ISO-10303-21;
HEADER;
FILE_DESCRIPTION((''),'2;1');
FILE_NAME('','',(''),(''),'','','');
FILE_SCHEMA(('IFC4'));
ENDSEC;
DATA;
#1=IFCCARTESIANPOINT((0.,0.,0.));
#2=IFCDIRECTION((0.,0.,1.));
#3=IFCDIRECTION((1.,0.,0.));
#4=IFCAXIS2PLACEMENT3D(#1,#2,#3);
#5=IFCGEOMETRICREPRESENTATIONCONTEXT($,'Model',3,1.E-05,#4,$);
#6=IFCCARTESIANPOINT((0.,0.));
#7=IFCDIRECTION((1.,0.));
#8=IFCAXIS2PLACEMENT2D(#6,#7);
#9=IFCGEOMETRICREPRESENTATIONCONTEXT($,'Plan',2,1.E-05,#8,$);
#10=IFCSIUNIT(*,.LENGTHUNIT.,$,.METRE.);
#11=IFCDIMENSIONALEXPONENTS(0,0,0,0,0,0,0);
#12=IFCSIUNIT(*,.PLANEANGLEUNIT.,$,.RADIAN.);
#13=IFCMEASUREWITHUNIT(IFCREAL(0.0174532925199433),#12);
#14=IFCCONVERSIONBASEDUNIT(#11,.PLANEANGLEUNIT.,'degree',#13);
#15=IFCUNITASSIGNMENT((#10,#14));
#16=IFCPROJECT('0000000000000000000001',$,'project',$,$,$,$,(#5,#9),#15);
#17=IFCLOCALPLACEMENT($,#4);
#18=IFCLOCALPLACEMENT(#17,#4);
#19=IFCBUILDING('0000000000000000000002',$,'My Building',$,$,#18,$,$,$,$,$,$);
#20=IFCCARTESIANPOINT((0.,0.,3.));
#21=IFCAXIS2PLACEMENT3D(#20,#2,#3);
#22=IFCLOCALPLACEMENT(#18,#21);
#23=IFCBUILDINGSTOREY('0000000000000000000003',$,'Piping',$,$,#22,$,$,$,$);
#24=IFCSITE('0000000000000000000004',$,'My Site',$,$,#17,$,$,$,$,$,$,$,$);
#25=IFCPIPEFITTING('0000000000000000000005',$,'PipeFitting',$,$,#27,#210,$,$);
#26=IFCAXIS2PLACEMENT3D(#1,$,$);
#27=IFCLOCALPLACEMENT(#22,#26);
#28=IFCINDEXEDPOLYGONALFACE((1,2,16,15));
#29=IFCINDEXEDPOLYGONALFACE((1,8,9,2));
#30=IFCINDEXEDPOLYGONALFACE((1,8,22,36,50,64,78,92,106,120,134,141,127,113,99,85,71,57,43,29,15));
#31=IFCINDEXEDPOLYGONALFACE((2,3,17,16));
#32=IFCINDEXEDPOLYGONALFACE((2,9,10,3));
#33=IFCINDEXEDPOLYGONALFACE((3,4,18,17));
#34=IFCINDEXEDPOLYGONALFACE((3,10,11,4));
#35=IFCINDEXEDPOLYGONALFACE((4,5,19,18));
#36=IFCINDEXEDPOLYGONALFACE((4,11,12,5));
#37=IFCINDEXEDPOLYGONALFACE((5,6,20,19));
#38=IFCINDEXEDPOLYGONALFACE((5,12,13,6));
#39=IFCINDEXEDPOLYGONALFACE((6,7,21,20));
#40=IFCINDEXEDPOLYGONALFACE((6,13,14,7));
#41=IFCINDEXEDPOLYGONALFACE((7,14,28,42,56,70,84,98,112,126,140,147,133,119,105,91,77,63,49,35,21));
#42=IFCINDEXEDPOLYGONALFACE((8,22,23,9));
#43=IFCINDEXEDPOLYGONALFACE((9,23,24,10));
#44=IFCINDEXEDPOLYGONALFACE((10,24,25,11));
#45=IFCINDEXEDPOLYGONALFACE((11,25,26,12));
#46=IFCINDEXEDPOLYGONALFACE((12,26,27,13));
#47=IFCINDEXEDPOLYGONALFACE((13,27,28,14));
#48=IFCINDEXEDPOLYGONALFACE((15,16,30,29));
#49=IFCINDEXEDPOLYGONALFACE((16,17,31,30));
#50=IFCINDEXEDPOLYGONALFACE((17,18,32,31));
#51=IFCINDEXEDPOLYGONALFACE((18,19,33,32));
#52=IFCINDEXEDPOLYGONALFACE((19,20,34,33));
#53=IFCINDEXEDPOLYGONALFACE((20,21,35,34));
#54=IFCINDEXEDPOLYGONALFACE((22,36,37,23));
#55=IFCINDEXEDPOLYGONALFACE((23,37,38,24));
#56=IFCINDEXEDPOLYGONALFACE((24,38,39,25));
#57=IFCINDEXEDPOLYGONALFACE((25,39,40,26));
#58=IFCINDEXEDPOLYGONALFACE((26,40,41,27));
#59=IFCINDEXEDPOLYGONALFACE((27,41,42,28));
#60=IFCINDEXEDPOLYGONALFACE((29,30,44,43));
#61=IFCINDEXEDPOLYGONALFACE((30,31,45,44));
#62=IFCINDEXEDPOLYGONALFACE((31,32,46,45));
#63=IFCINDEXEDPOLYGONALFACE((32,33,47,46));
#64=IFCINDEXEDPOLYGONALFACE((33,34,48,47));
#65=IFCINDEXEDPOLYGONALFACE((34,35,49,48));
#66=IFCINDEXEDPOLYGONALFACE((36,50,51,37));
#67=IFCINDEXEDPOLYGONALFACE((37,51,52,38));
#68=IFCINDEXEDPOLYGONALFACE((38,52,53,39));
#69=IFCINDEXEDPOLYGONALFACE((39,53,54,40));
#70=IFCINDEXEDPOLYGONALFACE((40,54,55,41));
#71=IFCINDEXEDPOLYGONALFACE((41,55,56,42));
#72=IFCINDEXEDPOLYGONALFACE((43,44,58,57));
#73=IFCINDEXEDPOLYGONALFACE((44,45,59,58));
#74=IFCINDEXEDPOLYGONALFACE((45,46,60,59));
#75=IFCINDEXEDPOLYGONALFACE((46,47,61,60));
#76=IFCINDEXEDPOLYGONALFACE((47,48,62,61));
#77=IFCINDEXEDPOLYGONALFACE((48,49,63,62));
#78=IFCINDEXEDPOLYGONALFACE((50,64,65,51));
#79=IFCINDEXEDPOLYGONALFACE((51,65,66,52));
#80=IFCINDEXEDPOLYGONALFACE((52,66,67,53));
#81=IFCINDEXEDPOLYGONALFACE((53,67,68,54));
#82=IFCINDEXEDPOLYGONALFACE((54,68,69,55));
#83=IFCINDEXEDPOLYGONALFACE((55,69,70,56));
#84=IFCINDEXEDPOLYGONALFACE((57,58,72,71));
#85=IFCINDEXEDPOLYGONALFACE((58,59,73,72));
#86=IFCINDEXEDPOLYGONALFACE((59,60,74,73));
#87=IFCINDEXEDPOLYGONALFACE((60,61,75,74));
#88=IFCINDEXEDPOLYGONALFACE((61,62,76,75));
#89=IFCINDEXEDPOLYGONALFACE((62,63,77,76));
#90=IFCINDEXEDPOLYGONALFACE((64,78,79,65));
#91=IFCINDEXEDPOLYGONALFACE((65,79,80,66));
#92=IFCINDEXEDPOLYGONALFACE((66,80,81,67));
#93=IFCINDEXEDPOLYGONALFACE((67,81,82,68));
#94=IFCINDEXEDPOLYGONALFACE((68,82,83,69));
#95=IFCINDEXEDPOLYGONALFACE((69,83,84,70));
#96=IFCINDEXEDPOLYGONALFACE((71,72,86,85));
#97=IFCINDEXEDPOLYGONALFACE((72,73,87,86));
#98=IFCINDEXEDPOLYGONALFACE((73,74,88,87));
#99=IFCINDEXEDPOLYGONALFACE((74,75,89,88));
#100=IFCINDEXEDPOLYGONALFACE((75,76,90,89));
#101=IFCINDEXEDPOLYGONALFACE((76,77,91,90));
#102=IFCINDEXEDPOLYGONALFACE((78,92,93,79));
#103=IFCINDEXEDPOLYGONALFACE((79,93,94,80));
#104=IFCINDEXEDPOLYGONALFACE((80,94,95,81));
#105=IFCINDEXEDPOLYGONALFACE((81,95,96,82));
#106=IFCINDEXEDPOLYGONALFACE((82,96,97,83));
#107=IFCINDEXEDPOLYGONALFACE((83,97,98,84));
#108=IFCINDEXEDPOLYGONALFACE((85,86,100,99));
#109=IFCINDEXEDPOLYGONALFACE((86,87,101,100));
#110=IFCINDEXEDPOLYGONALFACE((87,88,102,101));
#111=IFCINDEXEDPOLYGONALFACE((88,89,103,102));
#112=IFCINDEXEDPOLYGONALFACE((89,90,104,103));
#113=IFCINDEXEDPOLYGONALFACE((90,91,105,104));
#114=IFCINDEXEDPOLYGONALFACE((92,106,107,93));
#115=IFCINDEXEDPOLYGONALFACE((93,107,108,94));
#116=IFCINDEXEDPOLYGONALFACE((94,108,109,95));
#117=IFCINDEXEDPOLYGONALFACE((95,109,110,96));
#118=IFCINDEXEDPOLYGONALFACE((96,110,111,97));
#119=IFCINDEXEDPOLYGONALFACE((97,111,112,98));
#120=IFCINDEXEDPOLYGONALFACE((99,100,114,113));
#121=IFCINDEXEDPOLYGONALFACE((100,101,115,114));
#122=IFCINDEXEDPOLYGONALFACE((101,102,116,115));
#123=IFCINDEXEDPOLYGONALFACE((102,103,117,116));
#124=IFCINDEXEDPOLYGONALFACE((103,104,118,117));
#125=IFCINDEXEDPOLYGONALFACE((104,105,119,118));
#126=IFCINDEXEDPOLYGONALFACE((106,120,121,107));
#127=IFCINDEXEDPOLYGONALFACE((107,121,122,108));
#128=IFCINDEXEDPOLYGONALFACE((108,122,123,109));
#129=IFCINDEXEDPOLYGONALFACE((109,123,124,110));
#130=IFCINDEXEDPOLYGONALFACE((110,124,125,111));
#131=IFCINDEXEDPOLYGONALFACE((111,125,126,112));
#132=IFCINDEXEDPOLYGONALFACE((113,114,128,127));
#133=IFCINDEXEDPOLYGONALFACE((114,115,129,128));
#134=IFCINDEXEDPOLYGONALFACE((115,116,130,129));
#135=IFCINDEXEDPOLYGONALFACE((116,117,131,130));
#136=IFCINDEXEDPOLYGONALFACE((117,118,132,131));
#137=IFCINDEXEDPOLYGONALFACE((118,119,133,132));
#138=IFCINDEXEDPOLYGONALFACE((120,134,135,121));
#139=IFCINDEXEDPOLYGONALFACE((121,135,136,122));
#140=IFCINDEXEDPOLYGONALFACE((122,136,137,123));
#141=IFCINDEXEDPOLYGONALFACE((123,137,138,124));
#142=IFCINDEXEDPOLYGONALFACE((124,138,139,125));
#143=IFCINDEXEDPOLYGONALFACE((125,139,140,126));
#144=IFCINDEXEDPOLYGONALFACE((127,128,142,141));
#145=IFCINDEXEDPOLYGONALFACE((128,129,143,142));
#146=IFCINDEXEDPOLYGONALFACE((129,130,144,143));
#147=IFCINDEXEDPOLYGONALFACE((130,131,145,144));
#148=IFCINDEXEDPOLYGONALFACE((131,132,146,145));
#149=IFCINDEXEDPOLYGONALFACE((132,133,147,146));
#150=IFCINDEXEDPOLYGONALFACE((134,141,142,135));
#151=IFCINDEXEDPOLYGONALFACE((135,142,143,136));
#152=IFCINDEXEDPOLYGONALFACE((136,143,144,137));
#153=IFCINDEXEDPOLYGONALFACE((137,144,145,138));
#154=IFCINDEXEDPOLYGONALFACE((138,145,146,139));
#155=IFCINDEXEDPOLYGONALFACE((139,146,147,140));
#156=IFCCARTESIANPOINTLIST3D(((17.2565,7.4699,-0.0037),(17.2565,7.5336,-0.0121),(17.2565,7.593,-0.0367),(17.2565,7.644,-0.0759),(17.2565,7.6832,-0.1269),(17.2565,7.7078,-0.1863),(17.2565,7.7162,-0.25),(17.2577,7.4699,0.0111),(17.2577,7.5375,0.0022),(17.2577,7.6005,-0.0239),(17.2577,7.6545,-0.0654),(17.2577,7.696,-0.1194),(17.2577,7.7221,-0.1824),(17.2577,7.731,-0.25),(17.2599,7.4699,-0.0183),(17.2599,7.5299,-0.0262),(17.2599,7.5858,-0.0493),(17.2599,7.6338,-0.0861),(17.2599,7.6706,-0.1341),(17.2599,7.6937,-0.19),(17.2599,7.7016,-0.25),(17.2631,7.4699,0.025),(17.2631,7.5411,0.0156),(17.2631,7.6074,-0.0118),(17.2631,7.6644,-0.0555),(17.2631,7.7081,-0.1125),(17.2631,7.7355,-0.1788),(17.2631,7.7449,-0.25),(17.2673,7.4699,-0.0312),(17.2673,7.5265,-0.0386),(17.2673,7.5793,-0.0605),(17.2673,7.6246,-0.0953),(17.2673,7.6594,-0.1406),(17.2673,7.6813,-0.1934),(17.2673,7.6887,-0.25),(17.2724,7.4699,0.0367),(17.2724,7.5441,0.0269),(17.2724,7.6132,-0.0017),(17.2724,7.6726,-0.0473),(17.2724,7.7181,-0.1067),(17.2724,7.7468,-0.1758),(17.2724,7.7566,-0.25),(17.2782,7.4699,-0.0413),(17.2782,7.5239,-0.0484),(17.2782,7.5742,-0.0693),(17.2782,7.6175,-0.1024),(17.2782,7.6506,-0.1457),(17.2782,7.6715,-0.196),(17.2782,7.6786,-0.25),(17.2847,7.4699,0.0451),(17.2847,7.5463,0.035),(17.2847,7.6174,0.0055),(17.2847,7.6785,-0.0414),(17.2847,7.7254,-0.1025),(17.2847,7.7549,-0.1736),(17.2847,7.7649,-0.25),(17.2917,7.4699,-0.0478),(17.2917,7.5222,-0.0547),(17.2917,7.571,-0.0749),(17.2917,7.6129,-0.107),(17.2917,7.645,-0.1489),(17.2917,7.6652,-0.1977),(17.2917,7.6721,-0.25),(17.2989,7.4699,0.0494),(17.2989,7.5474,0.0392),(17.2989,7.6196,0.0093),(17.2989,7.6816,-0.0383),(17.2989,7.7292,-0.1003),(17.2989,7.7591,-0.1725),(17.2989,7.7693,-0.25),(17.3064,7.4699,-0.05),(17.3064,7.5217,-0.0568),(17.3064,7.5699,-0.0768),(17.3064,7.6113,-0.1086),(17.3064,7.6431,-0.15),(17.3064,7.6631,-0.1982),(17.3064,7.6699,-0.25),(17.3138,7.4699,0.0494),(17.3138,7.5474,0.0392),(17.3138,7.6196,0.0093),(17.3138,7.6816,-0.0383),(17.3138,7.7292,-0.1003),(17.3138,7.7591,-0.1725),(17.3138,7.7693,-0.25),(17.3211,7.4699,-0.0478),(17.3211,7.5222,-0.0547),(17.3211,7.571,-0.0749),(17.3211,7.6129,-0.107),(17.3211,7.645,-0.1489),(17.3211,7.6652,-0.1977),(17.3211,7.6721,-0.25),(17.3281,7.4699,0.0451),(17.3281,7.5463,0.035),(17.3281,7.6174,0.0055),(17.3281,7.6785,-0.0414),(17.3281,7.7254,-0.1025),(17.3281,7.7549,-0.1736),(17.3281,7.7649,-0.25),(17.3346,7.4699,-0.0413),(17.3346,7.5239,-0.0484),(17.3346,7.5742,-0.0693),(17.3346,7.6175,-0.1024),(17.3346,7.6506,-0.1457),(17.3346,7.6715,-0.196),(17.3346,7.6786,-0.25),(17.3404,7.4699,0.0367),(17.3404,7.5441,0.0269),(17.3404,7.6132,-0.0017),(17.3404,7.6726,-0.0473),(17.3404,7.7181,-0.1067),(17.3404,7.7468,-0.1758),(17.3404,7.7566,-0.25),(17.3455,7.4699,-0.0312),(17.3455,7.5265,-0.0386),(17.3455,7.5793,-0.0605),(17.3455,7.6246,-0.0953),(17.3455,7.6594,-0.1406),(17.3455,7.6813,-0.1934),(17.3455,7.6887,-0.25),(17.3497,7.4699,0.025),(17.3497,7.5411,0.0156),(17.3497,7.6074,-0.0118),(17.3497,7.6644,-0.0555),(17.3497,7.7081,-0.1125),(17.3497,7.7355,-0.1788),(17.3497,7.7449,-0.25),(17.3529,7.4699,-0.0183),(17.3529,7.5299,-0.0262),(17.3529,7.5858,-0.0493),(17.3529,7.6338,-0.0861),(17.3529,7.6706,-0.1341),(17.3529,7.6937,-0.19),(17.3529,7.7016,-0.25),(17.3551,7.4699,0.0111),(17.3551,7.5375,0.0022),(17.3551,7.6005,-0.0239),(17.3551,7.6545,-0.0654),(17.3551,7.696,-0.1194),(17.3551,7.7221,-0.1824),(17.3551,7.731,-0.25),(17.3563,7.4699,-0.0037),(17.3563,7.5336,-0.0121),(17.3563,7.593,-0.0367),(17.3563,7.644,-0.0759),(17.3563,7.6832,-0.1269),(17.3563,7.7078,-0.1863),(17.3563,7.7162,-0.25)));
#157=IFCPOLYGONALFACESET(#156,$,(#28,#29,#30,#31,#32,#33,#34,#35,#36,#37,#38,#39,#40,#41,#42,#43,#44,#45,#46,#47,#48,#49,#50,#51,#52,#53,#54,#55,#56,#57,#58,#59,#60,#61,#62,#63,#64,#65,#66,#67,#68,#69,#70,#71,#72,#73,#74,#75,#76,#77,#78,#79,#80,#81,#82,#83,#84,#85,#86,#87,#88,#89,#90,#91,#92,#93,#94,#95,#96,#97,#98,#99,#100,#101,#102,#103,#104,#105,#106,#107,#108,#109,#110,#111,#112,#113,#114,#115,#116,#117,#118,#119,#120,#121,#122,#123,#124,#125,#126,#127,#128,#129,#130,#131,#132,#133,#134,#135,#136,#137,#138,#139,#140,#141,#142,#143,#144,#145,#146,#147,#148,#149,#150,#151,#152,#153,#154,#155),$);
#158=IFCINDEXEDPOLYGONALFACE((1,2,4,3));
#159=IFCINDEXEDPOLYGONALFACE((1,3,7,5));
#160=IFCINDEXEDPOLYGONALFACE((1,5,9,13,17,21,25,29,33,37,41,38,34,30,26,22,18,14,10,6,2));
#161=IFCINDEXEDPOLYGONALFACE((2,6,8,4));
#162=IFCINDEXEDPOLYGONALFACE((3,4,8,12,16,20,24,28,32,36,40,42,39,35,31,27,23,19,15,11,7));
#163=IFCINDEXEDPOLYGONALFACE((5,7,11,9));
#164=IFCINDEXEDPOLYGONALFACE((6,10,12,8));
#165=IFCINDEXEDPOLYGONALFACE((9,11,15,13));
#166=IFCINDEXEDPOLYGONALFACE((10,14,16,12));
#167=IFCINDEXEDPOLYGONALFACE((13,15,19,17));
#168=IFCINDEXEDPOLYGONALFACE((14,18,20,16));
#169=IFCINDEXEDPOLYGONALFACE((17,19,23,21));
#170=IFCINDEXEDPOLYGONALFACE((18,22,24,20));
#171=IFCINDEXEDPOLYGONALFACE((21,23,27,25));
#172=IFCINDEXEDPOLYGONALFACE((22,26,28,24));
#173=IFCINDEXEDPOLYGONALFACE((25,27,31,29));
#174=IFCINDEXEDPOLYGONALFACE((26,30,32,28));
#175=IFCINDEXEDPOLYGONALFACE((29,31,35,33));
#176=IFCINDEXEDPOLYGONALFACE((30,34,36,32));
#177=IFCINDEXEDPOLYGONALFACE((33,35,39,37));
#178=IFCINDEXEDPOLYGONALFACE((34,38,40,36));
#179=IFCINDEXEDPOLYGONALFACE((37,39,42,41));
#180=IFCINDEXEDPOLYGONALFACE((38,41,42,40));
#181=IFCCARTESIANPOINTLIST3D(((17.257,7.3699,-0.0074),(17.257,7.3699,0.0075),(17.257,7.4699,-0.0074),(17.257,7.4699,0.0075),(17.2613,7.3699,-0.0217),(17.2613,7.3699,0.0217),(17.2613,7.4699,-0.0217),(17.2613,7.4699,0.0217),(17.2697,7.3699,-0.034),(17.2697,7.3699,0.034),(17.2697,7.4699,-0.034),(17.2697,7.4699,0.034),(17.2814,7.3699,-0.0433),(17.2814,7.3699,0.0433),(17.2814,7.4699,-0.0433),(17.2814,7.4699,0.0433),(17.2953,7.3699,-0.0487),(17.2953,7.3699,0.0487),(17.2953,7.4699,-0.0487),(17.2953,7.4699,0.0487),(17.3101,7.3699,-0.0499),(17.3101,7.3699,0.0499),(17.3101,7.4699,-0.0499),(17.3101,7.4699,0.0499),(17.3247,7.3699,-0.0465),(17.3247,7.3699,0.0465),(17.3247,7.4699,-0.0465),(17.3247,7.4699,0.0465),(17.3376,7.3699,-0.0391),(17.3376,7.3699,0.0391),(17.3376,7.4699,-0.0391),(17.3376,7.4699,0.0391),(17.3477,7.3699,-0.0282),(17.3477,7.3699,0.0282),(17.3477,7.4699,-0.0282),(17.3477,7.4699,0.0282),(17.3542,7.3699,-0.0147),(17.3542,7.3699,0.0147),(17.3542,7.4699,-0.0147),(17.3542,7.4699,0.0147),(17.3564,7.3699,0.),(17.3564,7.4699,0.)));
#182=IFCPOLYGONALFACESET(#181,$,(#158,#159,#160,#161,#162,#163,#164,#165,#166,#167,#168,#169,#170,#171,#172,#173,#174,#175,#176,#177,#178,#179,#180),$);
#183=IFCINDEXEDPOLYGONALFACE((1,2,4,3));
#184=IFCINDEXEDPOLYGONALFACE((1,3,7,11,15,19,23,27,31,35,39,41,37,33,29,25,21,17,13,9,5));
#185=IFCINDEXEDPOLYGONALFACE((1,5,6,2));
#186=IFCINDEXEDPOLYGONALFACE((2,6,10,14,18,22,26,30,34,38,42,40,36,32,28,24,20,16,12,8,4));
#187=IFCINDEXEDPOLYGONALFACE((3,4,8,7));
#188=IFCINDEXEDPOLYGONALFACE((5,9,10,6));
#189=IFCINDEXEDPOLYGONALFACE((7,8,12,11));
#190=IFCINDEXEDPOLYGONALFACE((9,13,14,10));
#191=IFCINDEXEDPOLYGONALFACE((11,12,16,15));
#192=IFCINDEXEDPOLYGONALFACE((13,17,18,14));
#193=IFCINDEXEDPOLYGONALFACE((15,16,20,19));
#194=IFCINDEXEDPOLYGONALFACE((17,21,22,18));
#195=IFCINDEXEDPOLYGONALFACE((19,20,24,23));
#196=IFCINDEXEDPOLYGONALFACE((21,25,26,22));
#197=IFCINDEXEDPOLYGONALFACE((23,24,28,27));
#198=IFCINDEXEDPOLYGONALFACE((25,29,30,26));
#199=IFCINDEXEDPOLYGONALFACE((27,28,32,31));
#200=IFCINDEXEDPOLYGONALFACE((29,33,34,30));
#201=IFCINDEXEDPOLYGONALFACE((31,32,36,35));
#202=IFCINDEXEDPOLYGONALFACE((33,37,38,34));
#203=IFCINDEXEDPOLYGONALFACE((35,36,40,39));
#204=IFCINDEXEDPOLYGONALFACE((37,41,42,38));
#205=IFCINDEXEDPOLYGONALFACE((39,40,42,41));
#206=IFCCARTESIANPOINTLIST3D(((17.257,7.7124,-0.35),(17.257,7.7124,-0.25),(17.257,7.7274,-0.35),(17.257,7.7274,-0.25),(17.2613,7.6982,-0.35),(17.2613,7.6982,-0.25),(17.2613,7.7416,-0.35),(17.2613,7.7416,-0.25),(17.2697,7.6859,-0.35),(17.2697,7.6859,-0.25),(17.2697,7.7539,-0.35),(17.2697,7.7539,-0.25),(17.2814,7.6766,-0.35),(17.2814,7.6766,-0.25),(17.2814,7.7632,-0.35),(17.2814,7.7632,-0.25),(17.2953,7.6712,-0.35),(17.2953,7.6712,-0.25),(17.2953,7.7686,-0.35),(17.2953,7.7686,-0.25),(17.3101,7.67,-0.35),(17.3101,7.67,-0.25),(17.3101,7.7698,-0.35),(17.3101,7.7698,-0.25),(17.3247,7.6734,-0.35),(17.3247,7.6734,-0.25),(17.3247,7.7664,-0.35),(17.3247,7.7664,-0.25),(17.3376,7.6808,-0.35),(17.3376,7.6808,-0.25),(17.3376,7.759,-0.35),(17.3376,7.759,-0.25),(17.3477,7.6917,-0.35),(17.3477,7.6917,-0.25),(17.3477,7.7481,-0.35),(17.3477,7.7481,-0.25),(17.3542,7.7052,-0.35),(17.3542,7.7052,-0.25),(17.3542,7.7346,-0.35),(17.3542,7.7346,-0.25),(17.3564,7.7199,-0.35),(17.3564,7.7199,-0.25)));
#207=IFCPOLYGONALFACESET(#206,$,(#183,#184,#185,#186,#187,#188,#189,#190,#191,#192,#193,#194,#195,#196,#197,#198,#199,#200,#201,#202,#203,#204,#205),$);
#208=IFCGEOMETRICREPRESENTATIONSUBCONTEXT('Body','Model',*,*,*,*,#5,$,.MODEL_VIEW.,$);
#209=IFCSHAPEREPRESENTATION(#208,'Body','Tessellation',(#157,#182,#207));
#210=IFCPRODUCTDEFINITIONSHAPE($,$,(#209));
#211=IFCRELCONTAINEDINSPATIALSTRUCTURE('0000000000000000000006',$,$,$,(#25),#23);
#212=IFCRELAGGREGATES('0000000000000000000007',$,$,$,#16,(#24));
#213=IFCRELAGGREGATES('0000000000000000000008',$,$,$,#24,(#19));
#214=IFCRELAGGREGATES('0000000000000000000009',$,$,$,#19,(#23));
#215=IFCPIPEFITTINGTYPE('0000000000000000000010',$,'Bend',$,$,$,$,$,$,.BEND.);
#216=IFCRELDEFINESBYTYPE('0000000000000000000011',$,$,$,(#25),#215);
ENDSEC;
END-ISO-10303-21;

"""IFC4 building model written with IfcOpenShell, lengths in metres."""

from ifc_helpers import new_model, entity, si_unit, converted_unit, frame, origin_with_axes, origin_2d_with_axis, place, context, subcontext, project, spatial, circle, extrude, source, transform, mapped, type_object, type_shapes, element, save


model = new_model("IFC4")

# Units and contexts
model_context = context("Model", 3, precision=1e-05, world=origin_with_axes())
plan_context = context("Plan", 2, precision=1e-05, world=origin_2d_with_axis())
body_context = subcontext(model_context, "Body", "Model", "MODEL_VIEW")
ifc_project = project(units=[si_unit("LENGTHUNIT", "METRE"), converted_unit("PLANEANGLEUNIT", "degree", entity("IfcReal", 0.0174532925199433), si_unit("PLANEANGLEUNIT", "RADIAN"), dimensions=[0, 0, 0, 0, 0, 0, 0])], contexts=[model_context, plan_context])

# Site, building, storey
site_placement = place(None, origin_with_axes())
site = spatial("IfcSite", under=ifc_project, at=site_placement, Name="My Site")
building_placement = place(site_placement, origin_with_axes())
building = spatial("IfcBuilding", under=site, at=building_placement, Name="My Building")
storey_placement = place(building_placement, frame((0.0, 0.0, 3.0), z_axis=(0.0, 0.0, 1.0), x_axis=(1.0, 0.0, 0.0)))
storey = spatial("IfcBuildingStorey", under=building, at=storey_placement, Name="Piping")

# Pipe fitting
pipe_fitting_type = type_object("IfcPipeFittingType", Name="Bend", PredefinedType="BEND")
shared_shape = source(origin_with_axes(), body_context, "Body", "SolidModel", [
    entity("IfcSweptDiskSolid", entity("IfcIndexedPolyCurve", entity("IfcCartesianPointList3D", [[0.0, 0.0, -0.1], [0.0, -0.0732, -0.2768], [0.0, -0.25, -0.35]]), [entity("IfcArcIndex", [1, 2, 3])]), 0.05),
    extrude(circle(Radius=0.05), origin_with_axes(), (0.0, 0.0, -1.0), 0.1),
    extrude(circle(Radius=0.05), frame((0.0, -0.25, -0.35), z_axis=(0.0, -1.0, 0.0), x_axis=(1.0, 0.0, 0.0)), (0.0, 0.0, 1.0), 0.1),
])
type_shapes(pipe_fitting_type, [shared_shape])
for number, where, z_axis, x_axis, name in (
    (1, (17.3064, 7.3699, 0.0), (0.0, -1.0, 0.0), (1.0, 0.0, 0.0), "PipeFitting"),
):
    element("IfcPipeFitting", number, at=place(storey_placement, frame(where, z_axis=z_axis, x_axis=x_axis)), inside=storey, type_object=pipe_fitting_type, Name=name, context=body_context, shape_type="MappedRepresentation", body=[
        mapped(shared_shape, transform((0.0, 0.0, 0.0), x_axis=(1.0, 0.0, 0.0), y_axis=(0.0, 1.0, 0.0), z_axis=(0.0, 0.0, 1.0), scale=1.0)),
    ])

save(model, "model.ifc")
